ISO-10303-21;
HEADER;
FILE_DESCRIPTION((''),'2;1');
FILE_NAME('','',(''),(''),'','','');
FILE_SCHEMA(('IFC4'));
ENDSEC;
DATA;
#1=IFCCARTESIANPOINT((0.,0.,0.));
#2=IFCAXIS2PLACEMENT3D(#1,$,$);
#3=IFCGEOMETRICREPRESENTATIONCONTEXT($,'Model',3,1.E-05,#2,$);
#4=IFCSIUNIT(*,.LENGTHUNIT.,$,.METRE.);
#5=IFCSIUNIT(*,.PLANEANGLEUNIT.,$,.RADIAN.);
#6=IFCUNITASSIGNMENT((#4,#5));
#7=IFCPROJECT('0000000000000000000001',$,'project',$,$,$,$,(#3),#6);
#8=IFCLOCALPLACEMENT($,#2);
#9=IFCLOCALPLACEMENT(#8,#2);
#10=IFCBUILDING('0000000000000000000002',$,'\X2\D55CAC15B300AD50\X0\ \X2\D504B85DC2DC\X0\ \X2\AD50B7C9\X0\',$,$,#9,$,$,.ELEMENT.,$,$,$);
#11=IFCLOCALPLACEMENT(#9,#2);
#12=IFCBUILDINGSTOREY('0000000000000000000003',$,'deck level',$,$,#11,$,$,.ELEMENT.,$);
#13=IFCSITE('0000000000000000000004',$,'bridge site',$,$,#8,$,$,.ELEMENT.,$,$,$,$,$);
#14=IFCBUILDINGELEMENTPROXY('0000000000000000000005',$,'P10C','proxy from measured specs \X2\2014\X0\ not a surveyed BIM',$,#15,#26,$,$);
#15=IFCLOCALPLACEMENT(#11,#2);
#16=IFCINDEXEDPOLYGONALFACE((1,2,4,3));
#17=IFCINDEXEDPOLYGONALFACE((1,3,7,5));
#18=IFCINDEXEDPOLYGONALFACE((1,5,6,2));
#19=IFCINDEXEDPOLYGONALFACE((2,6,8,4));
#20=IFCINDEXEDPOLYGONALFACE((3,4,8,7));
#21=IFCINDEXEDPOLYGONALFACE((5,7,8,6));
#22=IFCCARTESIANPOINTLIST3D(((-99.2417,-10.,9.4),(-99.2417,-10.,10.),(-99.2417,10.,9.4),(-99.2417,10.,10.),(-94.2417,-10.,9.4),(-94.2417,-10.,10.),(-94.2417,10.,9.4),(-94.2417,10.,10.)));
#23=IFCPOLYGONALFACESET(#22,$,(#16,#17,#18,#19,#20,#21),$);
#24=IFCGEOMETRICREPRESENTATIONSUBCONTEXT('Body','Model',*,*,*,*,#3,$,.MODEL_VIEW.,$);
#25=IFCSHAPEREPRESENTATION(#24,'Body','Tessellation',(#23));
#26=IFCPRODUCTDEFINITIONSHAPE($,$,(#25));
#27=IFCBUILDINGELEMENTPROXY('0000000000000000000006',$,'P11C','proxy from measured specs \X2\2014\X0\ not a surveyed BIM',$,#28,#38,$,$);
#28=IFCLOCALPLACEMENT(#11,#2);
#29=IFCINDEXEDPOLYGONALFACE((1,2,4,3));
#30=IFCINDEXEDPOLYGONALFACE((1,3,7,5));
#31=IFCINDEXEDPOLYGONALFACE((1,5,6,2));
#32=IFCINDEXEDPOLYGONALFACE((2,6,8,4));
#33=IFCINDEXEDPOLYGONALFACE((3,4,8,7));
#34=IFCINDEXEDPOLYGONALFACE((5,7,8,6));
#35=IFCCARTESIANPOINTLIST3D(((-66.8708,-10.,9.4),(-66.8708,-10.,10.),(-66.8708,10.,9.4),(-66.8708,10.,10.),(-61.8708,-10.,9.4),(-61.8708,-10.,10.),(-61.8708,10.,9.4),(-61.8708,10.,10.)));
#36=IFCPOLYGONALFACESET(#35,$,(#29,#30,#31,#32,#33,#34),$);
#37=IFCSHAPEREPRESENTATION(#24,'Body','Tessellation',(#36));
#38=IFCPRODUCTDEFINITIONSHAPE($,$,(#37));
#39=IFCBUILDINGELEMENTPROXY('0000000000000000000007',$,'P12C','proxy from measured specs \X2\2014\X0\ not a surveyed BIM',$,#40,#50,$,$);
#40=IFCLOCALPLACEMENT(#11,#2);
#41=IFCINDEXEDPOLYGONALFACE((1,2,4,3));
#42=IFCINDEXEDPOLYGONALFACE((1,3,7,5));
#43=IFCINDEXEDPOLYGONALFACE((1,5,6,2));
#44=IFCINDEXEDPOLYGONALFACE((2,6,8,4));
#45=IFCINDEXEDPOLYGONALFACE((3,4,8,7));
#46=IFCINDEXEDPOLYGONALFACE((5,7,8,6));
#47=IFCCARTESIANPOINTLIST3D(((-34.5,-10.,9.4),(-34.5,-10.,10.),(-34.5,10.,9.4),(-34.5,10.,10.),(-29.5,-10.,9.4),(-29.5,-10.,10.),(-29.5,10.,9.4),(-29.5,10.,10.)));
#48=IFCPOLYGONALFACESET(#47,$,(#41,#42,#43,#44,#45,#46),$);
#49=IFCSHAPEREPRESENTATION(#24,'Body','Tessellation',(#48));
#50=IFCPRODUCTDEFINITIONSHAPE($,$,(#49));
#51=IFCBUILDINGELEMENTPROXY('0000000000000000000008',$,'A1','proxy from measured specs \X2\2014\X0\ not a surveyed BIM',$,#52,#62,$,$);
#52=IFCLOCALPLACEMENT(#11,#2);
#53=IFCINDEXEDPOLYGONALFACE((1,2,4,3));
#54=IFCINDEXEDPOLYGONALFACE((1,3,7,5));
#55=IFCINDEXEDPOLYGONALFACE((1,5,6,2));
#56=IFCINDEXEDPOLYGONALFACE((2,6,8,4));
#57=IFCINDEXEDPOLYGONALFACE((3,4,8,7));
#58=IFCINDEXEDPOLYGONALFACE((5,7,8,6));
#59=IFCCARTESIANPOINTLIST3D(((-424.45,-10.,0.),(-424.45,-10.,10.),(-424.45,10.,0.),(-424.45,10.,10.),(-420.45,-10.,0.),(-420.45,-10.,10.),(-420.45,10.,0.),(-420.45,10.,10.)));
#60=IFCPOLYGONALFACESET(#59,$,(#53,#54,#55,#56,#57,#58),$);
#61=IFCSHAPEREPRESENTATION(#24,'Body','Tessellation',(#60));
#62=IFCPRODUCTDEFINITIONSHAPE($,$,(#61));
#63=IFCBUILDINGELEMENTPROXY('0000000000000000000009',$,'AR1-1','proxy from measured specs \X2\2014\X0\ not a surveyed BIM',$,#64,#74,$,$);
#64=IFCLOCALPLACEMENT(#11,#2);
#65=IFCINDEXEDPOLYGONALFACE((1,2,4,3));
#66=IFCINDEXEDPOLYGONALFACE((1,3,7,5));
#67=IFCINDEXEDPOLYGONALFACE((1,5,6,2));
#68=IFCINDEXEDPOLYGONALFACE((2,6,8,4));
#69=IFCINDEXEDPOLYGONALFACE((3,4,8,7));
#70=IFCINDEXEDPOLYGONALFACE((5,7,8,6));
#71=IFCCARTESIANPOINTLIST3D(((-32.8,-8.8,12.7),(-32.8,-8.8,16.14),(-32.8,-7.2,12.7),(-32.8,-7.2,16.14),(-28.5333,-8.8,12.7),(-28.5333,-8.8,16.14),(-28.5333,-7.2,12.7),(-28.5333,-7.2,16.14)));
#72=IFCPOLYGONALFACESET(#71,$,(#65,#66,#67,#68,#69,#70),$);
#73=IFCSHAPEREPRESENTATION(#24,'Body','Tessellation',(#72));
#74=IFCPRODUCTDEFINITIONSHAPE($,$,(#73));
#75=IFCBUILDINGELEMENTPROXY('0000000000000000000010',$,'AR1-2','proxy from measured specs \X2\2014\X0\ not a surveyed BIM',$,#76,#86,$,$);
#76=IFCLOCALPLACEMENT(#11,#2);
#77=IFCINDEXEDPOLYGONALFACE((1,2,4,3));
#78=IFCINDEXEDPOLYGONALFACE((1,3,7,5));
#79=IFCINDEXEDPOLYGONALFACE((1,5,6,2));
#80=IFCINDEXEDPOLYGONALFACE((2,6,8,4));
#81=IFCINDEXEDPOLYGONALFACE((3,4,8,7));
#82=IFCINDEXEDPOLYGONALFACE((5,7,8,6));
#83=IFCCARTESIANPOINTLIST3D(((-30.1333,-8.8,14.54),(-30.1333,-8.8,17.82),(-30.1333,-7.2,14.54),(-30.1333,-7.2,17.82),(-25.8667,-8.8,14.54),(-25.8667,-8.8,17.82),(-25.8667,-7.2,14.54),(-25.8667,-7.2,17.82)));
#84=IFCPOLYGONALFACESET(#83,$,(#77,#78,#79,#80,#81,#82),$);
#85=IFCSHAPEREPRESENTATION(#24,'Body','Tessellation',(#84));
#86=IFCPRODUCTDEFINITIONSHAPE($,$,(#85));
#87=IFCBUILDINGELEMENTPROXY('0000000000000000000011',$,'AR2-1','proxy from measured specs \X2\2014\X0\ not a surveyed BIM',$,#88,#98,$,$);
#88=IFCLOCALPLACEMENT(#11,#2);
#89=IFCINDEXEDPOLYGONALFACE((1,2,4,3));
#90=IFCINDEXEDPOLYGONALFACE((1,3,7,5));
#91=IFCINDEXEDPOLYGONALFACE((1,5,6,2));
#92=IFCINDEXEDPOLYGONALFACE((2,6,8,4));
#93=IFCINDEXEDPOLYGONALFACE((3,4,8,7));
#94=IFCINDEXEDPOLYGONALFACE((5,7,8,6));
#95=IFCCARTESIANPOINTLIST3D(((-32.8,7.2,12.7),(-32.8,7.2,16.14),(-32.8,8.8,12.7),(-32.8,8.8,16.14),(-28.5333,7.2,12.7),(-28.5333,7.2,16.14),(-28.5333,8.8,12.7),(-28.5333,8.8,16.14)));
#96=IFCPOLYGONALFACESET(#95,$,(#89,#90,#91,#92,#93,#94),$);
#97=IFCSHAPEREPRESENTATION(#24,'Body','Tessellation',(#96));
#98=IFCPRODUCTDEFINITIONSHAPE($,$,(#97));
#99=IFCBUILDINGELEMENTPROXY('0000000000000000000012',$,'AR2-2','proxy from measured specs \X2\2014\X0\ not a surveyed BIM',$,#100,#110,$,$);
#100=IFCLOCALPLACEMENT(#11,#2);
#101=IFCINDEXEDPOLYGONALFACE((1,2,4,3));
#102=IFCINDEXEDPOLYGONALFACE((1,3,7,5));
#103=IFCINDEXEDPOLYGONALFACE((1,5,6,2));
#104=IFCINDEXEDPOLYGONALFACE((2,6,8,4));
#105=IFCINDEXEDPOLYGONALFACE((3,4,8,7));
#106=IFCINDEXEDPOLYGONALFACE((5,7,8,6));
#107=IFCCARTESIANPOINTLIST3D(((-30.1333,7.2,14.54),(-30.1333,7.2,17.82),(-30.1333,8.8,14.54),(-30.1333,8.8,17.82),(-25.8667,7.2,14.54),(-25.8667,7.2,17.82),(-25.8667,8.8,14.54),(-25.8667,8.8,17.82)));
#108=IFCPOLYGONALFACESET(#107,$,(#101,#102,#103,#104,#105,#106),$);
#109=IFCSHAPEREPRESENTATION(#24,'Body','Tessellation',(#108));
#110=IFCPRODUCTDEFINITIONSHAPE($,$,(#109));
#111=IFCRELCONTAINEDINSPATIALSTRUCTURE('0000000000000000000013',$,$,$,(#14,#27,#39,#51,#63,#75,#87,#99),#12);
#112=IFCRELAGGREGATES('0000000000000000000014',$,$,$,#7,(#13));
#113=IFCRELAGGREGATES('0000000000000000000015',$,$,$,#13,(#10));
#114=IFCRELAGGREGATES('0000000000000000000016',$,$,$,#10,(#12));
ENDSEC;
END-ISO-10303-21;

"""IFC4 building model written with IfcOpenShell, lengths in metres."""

from ifc_helpers import new_model, si_unit, frame, origin, origin_2d, place, context, subcontext, project, spatial, rectangle, extrude, element, save


model = new_model("IFC4")

# Units and contexts
model_context = context("Model", 3, precision=1e-05, world=origin())
body_context = subcontext(model_context, "Body", "Model", "MODEL_VIEW")
ifc_project = project(units=[si_unit("LENGTHUNIT", "METRE"), si_unit("PLANEANGLEUNIT", "RADIAN")], contexts=[model_context])

# Site, building, storey
site_placement = place(None, origin())
site = spatial("IfcSite", under=ifc_project, at=site_placement, Name="bridge site", CompositionType="ELEMENT")
building_placement = place(site_placement, origin())
building = spatial("IfcBuilding", under=site, at=building_placement, Name="한강대교 프록시 교량", CompositionType="ELEMENT")
storey_placement = place(building_placement, origin())
storey = spatial("IfcBuildingStorey", under=building, at=storey_placement, Name="deck level", CompositionType="ELEMENT")

# Building element proxies
for number, where, name in (
    (1, (-96.7417, 0.0, 9.4), "P10C"),
    (2, (-64.3708, 0.0, 9.4), "P11C"),
    (3, (-32.0, 0.0, 9.4), "P12C"),
):
    element("IfcBuildingElementProxy", number, at=place(storey_placement, frame(where)), inside=storey, Name=name, Description="proxy from measured specs — not a surveyed BIM", context=body_context, shape_type="SweptSolid", body=[
        extrude(rectangle(XDim=5.0, YDim=20.0, at=origin_2d()), origin(), (0.0, 0.0, 1.0), 0.6),
    ])
proxy_1_placement = place(storey_placement, frame((-422.45, 0.0, 0.0)))
element("IfcBuildingElementProxy", 4, at=proxy_1_placement, inside=storey, Name="A1", Description="proxy from measured specs — not a surveyed BIM", context=body_context, shape_type="SweptSolid", body=[
    extrude(rectangle(XDim=4.0, YDim=20.0, at=origin_2d()), origin(), (0.0, 0.0, 1.0), 10.0),
])
proxy_2_placement = place(storey_placement, frame((-30.6667, -8.0, 12.7)))
element("IfcBuildingElementProxy", 5, at=proxy_2_placement, inside=storey, Name="AR1-1", Description="proxy from measured specs — not a surveyed BIM", context=body_context, shape_type="SweptSolid", body=[
    extrude(rectangle(XDim=4.2667, YDim=1.6, at=origin_2d()), origin(), (0.0, 0.0, 1.0), 3.44),
])
proxy_3_placement = place(storey_placement, frame((-28.0, -8.0, 14.54)))
element("IfcBuildingElementProxy", 6, at=proxy_3_placement, inside=storey, Name="AR1-2", Description="proxy from measured specs — not a surveyed BIM", context=body_context, shape_type="SweptSolid", body=[
    extrude(rectangle(XDim=4.2667, YDim=1.6, at=origin_2d()), origin(), (0.0, 0.0, 1.0), 3.28),
])
proxy_4_placement = place(storey_placement, frame((-30.6667, 8.0, 12.7)))
element("IfcBuildingElementProxy", 7, at=proxy_4_placement, inside=storey, Name="AR2-1", Description="proxy from measured specs — not a surveyed BIM", context=body_context, shape_type="SweptSolid", body=[
    extrude(rectangle(XDim=4.2667, YDim=1.6, at=origin_2d()), origin(), (0.0, 0.0, 1.0), 3.44),
])
proxy_5_placement = place(storey_placement, frame((-28.0, 8.0, 14.54)))
element("IfcBuildingElementProxy", 8, at=proxy_5_placement, inside=storey, Name="AR2-2", Description="proxy from measured specs — not a surveyed BIM", context=body_context, shape_type="SweptSolid", body=[
    extrude(rectangle(XDim=4.2667, YDim=1.6, at=origin_2d()), origin(), (0.0, 0.0, 1.0), 3.28),
])

save(model, "model.ifc")
